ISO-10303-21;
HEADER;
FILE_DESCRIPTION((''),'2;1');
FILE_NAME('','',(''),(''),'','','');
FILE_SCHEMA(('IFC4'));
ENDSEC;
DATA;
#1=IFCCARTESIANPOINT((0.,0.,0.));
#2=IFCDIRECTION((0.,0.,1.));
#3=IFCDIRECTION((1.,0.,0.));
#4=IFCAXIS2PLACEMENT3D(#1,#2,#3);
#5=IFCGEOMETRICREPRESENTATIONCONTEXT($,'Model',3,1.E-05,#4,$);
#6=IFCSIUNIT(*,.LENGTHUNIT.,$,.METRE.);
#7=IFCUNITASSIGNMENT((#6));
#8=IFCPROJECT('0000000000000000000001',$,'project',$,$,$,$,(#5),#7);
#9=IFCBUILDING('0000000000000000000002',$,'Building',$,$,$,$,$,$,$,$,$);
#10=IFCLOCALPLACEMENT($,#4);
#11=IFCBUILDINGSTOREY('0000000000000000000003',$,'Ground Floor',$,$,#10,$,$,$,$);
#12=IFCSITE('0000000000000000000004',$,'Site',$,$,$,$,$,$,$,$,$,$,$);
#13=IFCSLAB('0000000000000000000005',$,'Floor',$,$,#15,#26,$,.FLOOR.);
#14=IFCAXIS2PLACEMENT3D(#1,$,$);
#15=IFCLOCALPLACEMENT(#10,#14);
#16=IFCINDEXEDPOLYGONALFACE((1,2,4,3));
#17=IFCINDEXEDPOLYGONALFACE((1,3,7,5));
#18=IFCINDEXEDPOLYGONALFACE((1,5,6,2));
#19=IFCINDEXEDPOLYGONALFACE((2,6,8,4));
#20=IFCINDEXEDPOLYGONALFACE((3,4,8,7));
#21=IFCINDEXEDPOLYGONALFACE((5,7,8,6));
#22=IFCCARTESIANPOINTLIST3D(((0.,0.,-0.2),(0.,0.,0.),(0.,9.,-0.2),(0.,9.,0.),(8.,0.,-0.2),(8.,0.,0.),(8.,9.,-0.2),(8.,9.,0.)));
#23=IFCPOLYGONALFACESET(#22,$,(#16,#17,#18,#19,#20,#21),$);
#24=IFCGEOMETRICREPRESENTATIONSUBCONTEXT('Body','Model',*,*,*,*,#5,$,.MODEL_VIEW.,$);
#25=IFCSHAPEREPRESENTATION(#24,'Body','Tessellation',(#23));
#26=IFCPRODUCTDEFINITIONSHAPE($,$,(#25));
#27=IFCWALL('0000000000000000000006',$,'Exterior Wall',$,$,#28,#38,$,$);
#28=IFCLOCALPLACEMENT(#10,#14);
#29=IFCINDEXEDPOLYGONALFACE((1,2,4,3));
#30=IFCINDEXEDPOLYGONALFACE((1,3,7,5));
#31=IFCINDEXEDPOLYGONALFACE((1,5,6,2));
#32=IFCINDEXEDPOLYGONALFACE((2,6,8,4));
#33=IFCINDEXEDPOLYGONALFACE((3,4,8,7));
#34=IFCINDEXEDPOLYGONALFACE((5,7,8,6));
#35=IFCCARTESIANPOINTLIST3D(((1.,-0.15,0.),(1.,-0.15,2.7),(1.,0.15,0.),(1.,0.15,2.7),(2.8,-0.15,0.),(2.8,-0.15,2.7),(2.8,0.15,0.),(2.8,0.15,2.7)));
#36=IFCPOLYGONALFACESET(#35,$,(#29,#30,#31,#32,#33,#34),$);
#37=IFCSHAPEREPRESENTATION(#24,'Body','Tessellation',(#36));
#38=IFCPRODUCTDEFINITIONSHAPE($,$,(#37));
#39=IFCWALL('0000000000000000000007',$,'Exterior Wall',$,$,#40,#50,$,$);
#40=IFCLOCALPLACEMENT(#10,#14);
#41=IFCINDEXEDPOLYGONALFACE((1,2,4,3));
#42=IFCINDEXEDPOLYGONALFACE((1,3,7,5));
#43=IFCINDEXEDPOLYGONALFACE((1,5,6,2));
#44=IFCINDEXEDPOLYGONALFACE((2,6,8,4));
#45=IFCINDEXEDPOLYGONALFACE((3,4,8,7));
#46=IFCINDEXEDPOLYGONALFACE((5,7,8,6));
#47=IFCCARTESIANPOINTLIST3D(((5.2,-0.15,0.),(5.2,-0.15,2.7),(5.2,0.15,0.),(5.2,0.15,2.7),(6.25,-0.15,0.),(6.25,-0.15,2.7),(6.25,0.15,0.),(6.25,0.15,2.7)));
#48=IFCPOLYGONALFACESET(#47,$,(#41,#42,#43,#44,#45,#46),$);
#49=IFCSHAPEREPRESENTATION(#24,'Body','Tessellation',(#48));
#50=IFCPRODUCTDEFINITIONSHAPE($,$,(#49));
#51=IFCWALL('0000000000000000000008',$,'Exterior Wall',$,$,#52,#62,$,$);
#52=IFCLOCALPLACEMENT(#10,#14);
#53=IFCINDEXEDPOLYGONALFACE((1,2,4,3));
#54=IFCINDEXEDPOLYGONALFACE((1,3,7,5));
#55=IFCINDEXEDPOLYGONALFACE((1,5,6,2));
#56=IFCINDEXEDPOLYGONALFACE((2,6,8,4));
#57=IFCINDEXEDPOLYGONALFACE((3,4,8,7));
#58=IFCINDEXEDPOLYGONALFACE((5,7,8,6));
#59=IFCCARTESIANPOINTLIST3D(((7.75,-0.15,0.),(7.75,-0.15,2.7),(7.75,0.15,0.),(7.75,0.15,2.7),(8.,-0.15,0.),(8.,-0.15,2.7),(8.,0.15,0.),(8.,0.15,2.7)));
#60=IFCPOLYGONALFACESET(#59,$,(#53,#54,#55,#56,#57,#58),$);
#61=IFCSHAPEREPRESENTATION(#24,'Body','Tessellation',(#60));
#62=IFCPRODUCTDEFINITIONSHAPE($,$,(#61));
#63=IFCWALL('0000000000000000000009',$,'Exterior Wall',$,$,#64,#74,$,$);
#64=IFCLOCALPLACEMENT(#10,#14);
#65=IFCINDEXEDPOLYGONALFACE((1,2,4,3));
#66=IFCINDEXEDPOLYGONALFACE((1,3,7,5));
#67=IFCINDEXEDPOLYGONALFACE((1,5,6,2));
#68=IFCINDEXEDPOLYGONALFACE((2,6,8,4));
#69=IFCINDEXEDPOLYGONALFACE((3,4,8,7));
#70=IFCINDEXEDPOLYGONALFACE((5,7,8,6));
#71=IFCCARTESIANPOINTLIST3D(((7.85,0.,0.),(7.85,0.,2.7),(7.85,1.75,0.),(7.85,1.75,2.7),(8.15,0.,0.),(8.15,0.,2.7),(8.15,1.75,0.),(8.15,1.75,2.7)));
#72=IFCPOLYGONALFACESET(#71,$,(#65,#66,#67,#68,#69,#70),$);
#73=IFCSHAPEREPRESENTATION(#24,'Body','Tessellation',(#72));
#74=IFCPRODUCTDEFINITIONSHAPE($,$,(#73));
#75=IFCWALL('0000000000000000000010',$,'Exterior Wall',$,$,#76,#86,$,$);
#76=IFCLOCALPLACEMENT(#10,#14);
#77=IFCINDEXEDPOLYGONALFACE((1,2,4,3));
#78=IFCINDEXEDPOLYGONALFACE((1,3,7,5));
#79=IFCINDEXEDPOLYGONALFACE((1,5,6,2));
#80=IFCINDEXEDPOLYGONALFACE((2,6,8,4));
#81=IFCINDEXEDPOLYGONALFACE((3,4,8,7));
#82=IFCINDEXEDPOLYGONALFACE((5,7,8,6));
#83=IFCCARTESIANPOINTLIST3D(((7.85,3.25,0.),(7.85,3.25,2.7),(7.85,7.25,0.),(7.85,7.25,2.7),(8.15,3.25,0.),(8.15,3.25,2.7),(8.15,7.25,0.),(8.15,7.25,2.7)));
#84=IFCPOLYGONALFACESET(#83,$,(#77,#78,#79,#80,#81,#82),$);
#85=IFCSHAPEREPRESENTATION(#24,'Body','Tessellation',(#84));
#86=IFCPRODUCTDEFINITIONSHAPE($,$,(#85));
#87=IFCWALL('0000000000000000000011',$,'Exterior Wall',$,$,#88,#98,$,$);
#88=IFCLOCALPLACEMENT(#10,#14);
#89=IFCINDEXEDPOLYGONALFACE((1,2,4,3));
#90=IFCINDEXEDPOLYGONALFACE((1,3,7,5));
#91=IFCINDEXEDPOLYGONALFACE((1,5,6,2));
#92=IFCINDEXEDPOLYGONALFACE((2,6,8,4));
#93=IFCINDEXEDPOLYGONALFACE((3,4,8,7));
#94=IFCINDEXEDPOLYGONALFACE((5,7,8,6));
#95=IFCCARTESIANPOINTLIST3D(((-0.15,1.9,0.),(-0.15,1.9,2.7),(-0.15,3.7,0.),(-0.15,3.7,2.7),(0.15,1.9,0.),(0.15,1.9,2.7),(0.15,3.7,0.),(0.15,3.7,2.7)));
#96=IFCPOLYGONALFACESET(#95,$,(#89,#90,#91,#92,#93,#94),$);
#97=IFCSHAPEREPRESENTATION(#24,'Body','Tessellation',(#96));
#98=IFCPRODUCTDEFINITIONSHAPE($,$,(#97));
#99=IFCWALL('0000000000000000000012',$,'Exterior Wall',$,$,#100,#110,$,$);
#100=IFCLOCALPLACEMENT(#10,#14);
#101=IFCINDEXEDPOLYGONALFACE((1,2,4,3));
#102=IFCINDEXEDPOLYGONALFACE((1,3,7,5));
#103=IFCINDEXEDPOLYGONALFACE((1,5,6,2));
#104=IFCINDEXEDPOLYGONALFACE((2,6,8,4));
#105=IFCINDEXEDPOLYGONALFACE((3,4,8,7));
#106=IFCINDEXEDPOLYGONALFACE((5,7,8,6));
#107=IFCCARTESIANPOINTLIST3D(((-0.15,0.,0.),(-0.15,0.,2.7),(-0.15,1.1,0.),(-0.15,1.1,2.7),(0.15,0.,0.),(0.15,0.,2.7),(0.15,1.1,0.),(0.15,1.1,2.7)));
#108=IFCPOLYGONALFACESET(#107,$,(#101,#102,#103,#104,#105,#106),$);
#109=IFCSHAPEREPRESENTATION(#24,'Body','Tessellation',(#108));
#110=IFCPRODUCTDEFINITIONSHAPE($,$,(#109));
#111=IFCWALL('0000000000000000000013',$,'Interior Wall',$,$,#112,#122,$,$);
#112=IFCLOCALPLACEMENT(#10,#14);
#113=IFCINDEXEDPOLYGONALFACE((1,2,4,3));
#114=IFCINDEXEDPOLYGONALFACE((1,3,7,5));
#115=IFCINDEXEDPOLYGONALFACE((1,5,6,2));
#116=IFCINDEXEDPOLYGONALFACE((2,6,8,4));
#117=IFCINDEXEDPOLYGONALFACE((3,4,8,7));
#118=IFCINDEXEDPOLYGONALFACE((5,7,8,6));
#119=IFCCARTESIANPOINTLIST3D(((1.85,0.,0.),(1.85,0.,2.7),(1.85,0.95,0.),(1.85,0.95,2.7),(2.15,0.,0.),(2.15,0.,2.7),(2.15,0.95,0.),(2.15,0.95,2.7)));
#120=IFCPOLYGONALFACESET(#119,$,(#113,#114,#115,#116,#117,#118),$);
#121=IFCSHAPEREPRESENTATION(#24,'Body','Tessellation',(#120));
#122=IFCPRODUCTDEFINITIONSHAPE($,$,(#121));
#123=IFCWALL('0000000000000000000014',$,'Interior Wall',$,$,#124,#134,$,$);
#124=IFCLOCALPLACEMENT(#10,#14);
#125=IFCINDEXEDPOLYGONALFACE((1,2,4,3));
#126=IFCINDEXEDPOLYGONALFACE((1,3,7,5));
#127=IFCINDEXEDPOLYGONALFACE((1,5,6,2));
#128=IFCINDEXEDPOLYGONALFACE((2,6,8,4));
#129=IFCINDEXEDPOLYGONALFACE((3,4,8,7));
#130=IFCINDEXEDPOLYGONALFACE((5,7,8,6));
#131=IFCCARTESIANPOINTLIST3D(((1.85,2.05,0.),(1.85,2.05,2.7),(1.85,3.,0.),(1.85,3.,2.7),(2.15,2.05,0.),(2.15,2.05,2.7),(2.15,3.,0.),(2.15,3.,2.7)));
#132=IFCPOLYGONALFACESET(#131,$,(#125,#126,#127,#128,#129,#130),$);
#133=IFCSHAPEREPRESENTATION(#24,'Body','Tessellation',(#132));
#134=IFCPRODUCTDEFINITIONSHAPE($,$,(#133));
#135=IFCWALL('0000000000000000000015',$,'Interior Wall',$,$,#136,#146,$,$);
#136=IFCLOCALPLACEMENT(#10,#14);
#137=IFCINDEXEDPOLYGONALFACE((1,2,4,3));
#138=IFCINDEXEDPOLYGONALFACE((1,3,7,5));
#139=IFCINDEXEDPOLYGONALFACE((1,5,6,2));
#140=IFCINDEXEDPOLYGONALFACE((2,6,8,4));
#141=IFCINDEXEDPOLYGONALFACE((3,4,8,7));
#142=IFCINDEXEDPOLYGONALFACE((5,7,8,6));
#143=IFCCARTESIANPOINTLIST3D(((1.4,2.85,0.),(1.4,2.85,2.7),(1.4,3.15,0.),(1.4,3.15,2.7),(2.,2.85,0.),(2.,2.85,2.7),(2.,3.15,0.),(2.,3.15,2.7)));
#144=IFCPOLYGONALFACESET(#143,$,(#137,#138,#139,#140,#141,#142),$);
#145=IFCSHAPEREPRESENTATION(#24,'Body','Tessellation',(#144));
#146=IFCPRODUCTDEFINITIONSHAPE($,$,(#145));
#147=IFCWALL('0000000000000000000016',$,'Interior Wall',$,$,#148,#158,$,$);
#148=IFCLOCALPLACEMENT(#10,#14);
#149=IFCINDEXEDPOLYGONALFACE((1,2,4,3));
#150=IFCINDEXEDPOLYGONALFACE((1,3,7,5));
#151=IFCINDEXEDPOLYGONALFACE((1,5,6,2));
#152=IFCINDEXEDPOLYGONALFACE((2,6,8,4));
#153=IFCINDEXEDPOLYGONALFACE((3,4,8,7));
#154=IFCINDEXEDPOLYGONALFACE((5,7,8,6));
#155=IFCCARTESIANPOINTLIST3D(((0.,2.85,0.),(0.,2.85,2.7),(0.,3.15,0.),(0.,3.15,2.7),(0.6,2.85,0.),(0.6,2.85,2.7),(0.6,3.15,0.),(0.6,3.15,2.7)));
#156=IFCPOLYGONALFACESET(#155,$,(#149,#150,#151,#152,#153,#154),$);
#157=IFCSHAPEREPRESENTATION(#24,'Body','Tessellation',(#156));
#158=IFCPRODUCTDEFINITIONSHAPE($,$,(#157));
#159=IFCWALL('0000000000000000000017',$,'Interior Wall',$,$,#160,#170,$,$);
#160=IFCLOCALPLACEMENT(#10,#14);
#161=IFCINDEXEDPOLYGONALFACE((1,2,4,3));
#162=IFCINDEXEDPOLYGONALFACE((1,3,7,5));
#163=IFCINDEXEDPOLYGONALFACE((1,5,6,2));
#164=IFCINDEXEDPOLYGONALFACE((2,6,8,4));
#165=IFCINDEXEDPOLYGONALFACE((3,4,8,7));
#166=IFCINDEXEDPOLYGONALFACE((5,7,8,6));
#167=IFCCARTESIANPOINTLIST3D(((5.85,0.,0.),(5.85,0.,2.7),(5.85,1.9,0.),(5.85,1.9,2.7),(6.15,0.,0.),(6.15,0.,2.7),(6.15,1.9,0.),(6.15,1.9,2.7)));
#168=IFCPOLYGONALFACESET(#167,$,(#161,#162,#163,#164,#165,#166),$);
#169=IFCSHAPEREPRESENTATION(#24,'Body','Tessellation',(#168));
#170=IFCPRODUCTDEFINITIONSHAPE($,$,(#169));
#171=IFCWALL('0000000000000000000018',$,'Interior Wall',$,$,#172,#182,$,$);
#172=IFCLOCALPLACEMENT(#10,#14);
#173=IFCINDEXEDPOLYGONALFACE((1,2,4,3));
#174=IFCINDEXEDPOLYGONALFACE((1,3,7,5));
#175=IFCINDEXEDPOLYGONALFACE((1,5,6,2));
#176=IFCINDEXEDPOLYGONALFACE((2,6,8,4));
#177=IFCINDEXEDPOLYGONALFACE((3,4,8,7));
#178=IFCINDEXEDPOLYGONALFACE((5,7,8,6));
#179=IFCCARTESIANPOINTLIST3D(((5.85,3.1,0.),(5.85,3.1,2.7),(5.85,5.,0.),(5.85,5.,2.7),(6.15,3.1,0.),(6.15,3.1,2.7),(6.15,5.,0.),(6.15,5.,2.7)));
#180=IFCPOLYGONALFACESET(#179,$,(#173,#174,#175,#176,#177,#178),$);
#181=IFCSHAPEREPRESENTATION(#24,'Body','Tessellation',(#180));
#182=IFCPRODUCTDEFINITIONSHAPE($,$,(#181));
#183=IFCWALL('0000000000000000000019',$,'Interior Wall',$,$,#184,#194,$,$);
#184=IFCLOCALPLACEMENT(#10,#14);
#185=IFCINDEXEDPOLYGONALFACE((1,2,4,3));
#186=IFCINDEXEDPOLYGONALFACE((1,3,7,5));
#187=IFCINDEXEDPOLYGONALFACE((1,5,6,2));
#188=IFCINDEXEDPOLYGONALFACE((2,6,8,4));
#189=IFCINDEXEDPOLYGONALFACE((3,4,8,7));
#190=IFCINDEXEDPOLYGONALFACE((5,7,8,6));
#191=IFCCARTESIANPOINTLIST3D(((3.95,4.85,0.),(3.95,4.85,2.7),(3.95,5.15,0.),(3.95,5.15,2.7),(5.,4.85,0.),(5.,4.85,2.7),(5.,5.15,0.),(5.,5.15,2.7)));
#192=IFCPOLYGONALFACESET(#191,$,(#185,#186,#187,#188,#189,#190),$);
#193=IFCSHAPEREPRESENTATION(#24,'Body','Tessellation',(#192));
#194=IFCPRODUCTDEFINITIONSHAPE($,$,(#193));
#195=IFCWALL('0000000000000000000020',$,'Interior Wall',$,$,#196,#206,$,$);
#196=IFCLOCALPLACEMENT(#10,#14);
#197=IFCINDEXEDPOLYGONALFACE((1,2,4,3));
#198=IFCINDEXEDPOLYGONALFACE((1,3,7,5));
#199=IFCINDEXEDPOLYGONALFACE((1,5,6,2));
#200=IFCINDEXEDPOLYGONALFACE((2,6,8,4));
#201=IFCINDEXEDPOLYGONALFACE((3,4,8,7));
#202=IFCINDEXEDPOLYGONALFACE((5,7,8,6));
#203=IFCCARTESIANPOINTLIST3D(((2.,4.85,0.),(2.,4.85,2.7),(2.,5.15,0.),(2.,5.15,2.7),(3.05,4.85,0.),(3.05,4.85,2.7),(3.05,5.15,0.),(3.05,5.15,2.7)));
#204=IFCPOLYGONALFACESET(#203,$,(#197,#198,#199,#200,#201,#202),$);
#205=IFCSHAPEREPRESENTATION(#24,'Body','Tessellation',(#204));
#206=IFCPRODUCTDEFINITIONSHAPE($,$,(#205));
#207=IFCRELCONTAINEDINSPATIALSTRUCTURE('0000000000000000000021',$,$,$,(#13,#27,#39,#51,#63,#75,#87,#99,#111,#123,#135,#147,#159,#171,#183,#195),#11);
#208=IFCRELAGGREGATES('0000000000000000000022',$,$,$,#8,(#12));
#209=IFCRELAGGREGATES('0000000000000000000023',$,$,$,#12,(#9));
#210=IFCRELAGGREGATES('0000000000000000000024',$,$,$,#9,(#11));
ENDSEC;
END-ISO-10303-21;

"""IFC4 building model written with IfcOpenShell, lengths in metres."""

from ifc_helpers import new_model, si_unit, frame, origin_with_axes, place, context, subcontext, project, spatial, indexed_curve, outline, extrude, element, save


model = new_model("IFC4")

# Units and contexts
model_context = context("Model", 3, precision=1e-05, world=origin_with_axes())
body_context = subcontext(model_context, "Body", "Model", "MODEL_VIEW")
ifc_project = project(units=[si_unit("LENGTHUNIT", "METRE")], contexts=[model_context])

# Site, building, storey
site = spatial("IfcSite", under=ifc_project, Name="Site")
building = spatial("IfcBuilding", under=site, Name="Building")
storey_placement = place(None, origin_with_axes())
storey = spatial("IfcBuildingStorey", under=building, at=storey_placement, Name="Ground Floor")

# Slab
slab_placement = place(storey_placement, frame((0.0, 0.0, -0.2), z_axis=(0.0, 0.0, 1.0), x_axis=(1.0, 0.0, 0.0)))
element("IfcSlab", 1, at=slab_placement, inside=storey, Name="Floor", PredefinedType="FLOOR", context=body_context, shape_type="SweptSolid", body=[
    extrude(outline(indexed_curve([(0.0, 0.0), (8.0, 0.0), (8.0, 9.0), (0.0, 9.0)])), None, (0.0, 0.0, 1.0), 0.2),
])

# Walls
wall_1_placement = place(storey_placement, frame((1.0, 0.0, 0.0), z_axis=(0.0, 0.0, 1.0), x_axis=(1.0, 0.0, 0.0)))
element("IfcWall", 2, at=wall_1_placement, inside=storey, Name="Exterior Wall", context=body_context, shape_type="SweptSolid", body=[
    extrude(outline(indexed_curve([(0.0, 0.0), (0.0, 0.3), (1.8, 0.3), (1.8, 0.0), (0.0, 0.0)], self_intersect=False)), frame((0.0, -0.15, 0.0), z_axis=(0.0, 0.0, 1.0), x_axis=(1.0, 0.0, 0.0)), (0.0, 0.0, 1.0), 2.7),
])
wall_2_placement = place(storey_placement, frame((5.2, 0.0, 0.0), z_axis=(0.0, 0.0, 1.0), x_axis=(1.0, 0.0, 0.0)))
element("IfcWall", 3, at=wall_2_placement, inside=storey, Name="Exterior Wall", context=body_context, shape_type="SweptSolid", body=[
    extrude(outline(indexed_curve([(0.0, 0.0), (0.0, 0.3), (1.05, 0.3), (1.05, 0.0), (0.0, 0.0)], self_intersect=False)), frame((0.0, -0.15, 0.0), z_axis=(0.0, 0.0, 1.0), x_axis=(1.0, 0.0, 0.0)), (0.0, 0.0, 1.0), 2.7),
])
wall_3_placement = place(storey_placement, frame((7.75, 0.0, 0.0), z_axis=(0.0, 0.0, 1.0), x_axis=(1.0, 0.0, 0.0)))
element("IfcWall", 4, at=wall_3_placement, inside=storey, Name="Exterior Wall", context=body_context, shape_type="SweptSolid", body=[
    extrude(outline(indexed_curve([(0.0, 0.0), (0.0, 0.3), (0.25, 0.3), (0.25, 0.0), (0.0, 0.0)], self_intersect=False)), frame((0.0, -0.15, 0.0), z_axis=(0.0, 0.0, 1.0), x_axis=(1.0, 0.0, 0.0)), (0.0, 0.0, 1.0), 2.7),
])
wall_4_placement = place(storey_placement, frame((8.0, 0.0, 0.0), z_axis=(0.0, 0.0, 1.0), x_axis=(0.0, 1.0, 0.0)))
element("IfcWall", 5, at=wall_4_placement, inside=storey, Name="Exterior Wall", context=body_context, shape_type="SweptSolid", body=[
    extrude(outline(indexed_curve([(0.0, 0.0), (0.0, 0.3), (1.75, 0.3), (1.75, 0.0), (0.0, 0.0)], self_intersect=False)), frame((0.0, -0.15, 0.0), z_axis=(0.0, 0.0, 1.0), x_axis=(1.0, 0.0, 0.0)), (0.0, 0.0, 1.0), 2.7),
])
wall_5_placement = place(storey_placement, frame((8.0, 3.25, 0.0), z_axis=(0.0, 0.0, 1.0), x_axis=(0.0, 1.0, 0.0)))
element("IfcWall", 6, at=wall_5_placement, inside=storey, Name="Exterior Wall", context=body_context, shape_type="SweptSolid", body=[
    extrude(outline(indexed_curve([(0.0, 0.0), (0.0, 0.3), (4.0, 0.3), (4.0, 0.0), (0.0, 0.0)], self_intersect=False)), frame((0.0, -0.15, 0.0), z_axis=(0.0, 0.0, 1.0), x_axis=(1.0, 0.0, 0.0)), (0.0, 0.0, 1.0), 2.7),
])
wall_6_placement = place(storey_placement, frame((0.0, 3.7, 0.0), z_axis=(0.0, 0.0, 1.0), x_axis=(0.0, -1.0, 0.0)))
element("IfcWall", 7, at=wall_6_placement, inside=storey, Name="Exterior Wall", context=body_context, shape_type="SweptSolid", body=[
    extrude(outline(indexed_curve([(0.0, 0.0), (0.0, 0.3), (1.8, 0.3), (1.8, 0.0), (0.0, 0.0)], self_intersect=False)), frame((0.0, -0.15, 0.0), z_axis=(0.0, 0.0, 1.0), x_axis=(1.0, 0.0, 0.0)), (0.0, 0.0, 1.0), 2.7),
])
wall_7_placement = place(storey_placement, frame((0.0, 1.1, 0.0), z_axis=(0.0, 0.0, 1.0), x_axis=(0.0, -1.0, 0.0)))
element("IfcWall", 8, at=wall_7_placement, inside=storey, Name="Exterior Wall", context=body_context, shape_type="SweptSolid", body=[
    extrude(outline(indexed_curve([(0.0, 0.0), (0.0, 0.3), (1.1, 0.3), (1.1, 0.0), (0.0, 0.0)], self_intersect=False)), frame((0.0, -0.15, 0.0), z_axis=(0.0, 0.0, 1.0), x_axis=(1.0, 0.0, 0.0)), (0.0, 0.0, 1.0), 2.7),
])
wall_8_placement = place(storey_placement, frame((2.0, 0.0, 0.0), z_axis=(0.0, 0.0, 1.0), x_axis=(0.0, 1.0, 0.0)))
element("IfcWall", 9, at=wall_8_placement, inside=storey, Name="Interior Wall", context=body_context, shape_type="SweptSolid", body=[
    extrude(outline(indexed_curve([(0.0, 0.0), (0.0, 0.3), (0.95, 0.3), (0.95, 0.0), (0.0, 0.0)], self_intersect=False)), frame((0.0, -0.15, 0.0), z_axis=(0.0, 0.0, 1.0), x_axis=(1.0, 0.0, 0.0)), (0.0, 0.0, 1.0), 2.7),
])
wall_9_placement = place(storey_placement, frame((2.0, 2.05, 0.0), z_axis=(0.0, 0.0, 1.0), x_axis=(0.0, 1.0, 0.0)))
element("IfcWall", 10, at=wall_9_placement, inside=storey, Name="Interior Wall", context=body_context, shape_type="SweptSolid", body=[
    extrude(outline(indexed_curve([(0.0, 0.0), (0.0, 0.3), (0.95, 0.3), (0.95, 0.0), (0.0, 0.0)], self_intersect=False)), frame((0.0, -0.15, 0.0), z_axis=(0.0, 0.0, 1.0), x_axis=(1.0, 0.0, 0.0)), (0.0, 0.0, 1.0), 2.7),
])
for number, where, z_axis, x_axis, name in (
    (11, (2.0, 3.0, 0.0), (0.0, 0.0, 1.0), (-1.0, 0.0, 0.0), "Interior Wall"),
    (12, (0.6, 3.0, 0.0), (0.0, 0.0, 1.0), (-1.0, 0.0, 0.0), "Interior Wall"),
):
    element("IfcWall", number, at=place(storey_placement, frame(where, z_axis=z_axis, x_axis=x_axis)), inside=storey, Name=name, context=body_context, shape_type="SweptSolid", body=[
        extrude(outline(indexed_curve([(0.0, 0.0), (0.0, 0.3), (0.6, 0.3), (0.6, 0.0), (0.0, 0.0)], self_intersect=False)), frame((0.0, -0.15, 0.0), z_axis=(0.0, 0.0, 1.0), x_axis=(1.0, 0.0, 0.0)), (0.0, 0.0, 1.0), 2.7),
    ])
for number, where, z_axis, x_axis, name in (
    (13, (6.0, 0.0, 0.0), (0.0, 0.0, 1.0), (0.0, 1.0, 0.0), "Interior Wall"),
    (14, (6.0, 3.1, 0.0), (0.0, 0.0, 1.0), (0.0, 1.0, 0.0), "Interior Wall"),
):
    element("IfcWall", number, at=place(storey_placement, frame(where, z_axis=z_axis, x_axis=x_axis)), inside=storey, Name=name, context=body_context, shape_type="SweptSolid", body=[
        extrude(outline(indexed_curve([(0.0, 0.0), (0.0, 0.3), (1.9, 0.3), (1.9, 0.0), (0.0, 0.0)], self_intersect=False)), frame((0.0, -0.15, 0.0), z_axis=(0.0, 0.0, 1.0), x_axis=(1.0, 0.0, 0.0)), (0.0, 0.0, 1.0), 2.7),
    ])
for number, where, z_axis, x_axis, name in (
    (15, (5.0, 5.0, 0.0), (0.0, 0.0, 1.0), (-1.0, 0.0, 0.0), "Interior Wall"),
    (16, (3.05, 5.0, 0.0), (0.0, 0.0, 1.0), (-1.0, 0.0, 0.0), "Interior Wall"),
):
    element("IfcWall", number, at=place(storey_placement, frame(where, z_axis=z_axis, x_axis=x_axis)), inside=storey, Name=name, context=body_context, shape_type="SweptSolid", body=[
        extrude(outline(indexed_curve([(0.0, 0.0), (0.0, 0.3), (1.05, 0.3), (1.05, 0.0), (0.0, 0.0)], self_intersect=False)), frame((0.0, -0.15, 0.0), z_axis=(0.0, 0.0, 1.0), x_axis=(1.0, 0.0, 0.0)), (0.0, 0.0, 1.0), 2.7),
    ])

save(model, "model.ifc")
